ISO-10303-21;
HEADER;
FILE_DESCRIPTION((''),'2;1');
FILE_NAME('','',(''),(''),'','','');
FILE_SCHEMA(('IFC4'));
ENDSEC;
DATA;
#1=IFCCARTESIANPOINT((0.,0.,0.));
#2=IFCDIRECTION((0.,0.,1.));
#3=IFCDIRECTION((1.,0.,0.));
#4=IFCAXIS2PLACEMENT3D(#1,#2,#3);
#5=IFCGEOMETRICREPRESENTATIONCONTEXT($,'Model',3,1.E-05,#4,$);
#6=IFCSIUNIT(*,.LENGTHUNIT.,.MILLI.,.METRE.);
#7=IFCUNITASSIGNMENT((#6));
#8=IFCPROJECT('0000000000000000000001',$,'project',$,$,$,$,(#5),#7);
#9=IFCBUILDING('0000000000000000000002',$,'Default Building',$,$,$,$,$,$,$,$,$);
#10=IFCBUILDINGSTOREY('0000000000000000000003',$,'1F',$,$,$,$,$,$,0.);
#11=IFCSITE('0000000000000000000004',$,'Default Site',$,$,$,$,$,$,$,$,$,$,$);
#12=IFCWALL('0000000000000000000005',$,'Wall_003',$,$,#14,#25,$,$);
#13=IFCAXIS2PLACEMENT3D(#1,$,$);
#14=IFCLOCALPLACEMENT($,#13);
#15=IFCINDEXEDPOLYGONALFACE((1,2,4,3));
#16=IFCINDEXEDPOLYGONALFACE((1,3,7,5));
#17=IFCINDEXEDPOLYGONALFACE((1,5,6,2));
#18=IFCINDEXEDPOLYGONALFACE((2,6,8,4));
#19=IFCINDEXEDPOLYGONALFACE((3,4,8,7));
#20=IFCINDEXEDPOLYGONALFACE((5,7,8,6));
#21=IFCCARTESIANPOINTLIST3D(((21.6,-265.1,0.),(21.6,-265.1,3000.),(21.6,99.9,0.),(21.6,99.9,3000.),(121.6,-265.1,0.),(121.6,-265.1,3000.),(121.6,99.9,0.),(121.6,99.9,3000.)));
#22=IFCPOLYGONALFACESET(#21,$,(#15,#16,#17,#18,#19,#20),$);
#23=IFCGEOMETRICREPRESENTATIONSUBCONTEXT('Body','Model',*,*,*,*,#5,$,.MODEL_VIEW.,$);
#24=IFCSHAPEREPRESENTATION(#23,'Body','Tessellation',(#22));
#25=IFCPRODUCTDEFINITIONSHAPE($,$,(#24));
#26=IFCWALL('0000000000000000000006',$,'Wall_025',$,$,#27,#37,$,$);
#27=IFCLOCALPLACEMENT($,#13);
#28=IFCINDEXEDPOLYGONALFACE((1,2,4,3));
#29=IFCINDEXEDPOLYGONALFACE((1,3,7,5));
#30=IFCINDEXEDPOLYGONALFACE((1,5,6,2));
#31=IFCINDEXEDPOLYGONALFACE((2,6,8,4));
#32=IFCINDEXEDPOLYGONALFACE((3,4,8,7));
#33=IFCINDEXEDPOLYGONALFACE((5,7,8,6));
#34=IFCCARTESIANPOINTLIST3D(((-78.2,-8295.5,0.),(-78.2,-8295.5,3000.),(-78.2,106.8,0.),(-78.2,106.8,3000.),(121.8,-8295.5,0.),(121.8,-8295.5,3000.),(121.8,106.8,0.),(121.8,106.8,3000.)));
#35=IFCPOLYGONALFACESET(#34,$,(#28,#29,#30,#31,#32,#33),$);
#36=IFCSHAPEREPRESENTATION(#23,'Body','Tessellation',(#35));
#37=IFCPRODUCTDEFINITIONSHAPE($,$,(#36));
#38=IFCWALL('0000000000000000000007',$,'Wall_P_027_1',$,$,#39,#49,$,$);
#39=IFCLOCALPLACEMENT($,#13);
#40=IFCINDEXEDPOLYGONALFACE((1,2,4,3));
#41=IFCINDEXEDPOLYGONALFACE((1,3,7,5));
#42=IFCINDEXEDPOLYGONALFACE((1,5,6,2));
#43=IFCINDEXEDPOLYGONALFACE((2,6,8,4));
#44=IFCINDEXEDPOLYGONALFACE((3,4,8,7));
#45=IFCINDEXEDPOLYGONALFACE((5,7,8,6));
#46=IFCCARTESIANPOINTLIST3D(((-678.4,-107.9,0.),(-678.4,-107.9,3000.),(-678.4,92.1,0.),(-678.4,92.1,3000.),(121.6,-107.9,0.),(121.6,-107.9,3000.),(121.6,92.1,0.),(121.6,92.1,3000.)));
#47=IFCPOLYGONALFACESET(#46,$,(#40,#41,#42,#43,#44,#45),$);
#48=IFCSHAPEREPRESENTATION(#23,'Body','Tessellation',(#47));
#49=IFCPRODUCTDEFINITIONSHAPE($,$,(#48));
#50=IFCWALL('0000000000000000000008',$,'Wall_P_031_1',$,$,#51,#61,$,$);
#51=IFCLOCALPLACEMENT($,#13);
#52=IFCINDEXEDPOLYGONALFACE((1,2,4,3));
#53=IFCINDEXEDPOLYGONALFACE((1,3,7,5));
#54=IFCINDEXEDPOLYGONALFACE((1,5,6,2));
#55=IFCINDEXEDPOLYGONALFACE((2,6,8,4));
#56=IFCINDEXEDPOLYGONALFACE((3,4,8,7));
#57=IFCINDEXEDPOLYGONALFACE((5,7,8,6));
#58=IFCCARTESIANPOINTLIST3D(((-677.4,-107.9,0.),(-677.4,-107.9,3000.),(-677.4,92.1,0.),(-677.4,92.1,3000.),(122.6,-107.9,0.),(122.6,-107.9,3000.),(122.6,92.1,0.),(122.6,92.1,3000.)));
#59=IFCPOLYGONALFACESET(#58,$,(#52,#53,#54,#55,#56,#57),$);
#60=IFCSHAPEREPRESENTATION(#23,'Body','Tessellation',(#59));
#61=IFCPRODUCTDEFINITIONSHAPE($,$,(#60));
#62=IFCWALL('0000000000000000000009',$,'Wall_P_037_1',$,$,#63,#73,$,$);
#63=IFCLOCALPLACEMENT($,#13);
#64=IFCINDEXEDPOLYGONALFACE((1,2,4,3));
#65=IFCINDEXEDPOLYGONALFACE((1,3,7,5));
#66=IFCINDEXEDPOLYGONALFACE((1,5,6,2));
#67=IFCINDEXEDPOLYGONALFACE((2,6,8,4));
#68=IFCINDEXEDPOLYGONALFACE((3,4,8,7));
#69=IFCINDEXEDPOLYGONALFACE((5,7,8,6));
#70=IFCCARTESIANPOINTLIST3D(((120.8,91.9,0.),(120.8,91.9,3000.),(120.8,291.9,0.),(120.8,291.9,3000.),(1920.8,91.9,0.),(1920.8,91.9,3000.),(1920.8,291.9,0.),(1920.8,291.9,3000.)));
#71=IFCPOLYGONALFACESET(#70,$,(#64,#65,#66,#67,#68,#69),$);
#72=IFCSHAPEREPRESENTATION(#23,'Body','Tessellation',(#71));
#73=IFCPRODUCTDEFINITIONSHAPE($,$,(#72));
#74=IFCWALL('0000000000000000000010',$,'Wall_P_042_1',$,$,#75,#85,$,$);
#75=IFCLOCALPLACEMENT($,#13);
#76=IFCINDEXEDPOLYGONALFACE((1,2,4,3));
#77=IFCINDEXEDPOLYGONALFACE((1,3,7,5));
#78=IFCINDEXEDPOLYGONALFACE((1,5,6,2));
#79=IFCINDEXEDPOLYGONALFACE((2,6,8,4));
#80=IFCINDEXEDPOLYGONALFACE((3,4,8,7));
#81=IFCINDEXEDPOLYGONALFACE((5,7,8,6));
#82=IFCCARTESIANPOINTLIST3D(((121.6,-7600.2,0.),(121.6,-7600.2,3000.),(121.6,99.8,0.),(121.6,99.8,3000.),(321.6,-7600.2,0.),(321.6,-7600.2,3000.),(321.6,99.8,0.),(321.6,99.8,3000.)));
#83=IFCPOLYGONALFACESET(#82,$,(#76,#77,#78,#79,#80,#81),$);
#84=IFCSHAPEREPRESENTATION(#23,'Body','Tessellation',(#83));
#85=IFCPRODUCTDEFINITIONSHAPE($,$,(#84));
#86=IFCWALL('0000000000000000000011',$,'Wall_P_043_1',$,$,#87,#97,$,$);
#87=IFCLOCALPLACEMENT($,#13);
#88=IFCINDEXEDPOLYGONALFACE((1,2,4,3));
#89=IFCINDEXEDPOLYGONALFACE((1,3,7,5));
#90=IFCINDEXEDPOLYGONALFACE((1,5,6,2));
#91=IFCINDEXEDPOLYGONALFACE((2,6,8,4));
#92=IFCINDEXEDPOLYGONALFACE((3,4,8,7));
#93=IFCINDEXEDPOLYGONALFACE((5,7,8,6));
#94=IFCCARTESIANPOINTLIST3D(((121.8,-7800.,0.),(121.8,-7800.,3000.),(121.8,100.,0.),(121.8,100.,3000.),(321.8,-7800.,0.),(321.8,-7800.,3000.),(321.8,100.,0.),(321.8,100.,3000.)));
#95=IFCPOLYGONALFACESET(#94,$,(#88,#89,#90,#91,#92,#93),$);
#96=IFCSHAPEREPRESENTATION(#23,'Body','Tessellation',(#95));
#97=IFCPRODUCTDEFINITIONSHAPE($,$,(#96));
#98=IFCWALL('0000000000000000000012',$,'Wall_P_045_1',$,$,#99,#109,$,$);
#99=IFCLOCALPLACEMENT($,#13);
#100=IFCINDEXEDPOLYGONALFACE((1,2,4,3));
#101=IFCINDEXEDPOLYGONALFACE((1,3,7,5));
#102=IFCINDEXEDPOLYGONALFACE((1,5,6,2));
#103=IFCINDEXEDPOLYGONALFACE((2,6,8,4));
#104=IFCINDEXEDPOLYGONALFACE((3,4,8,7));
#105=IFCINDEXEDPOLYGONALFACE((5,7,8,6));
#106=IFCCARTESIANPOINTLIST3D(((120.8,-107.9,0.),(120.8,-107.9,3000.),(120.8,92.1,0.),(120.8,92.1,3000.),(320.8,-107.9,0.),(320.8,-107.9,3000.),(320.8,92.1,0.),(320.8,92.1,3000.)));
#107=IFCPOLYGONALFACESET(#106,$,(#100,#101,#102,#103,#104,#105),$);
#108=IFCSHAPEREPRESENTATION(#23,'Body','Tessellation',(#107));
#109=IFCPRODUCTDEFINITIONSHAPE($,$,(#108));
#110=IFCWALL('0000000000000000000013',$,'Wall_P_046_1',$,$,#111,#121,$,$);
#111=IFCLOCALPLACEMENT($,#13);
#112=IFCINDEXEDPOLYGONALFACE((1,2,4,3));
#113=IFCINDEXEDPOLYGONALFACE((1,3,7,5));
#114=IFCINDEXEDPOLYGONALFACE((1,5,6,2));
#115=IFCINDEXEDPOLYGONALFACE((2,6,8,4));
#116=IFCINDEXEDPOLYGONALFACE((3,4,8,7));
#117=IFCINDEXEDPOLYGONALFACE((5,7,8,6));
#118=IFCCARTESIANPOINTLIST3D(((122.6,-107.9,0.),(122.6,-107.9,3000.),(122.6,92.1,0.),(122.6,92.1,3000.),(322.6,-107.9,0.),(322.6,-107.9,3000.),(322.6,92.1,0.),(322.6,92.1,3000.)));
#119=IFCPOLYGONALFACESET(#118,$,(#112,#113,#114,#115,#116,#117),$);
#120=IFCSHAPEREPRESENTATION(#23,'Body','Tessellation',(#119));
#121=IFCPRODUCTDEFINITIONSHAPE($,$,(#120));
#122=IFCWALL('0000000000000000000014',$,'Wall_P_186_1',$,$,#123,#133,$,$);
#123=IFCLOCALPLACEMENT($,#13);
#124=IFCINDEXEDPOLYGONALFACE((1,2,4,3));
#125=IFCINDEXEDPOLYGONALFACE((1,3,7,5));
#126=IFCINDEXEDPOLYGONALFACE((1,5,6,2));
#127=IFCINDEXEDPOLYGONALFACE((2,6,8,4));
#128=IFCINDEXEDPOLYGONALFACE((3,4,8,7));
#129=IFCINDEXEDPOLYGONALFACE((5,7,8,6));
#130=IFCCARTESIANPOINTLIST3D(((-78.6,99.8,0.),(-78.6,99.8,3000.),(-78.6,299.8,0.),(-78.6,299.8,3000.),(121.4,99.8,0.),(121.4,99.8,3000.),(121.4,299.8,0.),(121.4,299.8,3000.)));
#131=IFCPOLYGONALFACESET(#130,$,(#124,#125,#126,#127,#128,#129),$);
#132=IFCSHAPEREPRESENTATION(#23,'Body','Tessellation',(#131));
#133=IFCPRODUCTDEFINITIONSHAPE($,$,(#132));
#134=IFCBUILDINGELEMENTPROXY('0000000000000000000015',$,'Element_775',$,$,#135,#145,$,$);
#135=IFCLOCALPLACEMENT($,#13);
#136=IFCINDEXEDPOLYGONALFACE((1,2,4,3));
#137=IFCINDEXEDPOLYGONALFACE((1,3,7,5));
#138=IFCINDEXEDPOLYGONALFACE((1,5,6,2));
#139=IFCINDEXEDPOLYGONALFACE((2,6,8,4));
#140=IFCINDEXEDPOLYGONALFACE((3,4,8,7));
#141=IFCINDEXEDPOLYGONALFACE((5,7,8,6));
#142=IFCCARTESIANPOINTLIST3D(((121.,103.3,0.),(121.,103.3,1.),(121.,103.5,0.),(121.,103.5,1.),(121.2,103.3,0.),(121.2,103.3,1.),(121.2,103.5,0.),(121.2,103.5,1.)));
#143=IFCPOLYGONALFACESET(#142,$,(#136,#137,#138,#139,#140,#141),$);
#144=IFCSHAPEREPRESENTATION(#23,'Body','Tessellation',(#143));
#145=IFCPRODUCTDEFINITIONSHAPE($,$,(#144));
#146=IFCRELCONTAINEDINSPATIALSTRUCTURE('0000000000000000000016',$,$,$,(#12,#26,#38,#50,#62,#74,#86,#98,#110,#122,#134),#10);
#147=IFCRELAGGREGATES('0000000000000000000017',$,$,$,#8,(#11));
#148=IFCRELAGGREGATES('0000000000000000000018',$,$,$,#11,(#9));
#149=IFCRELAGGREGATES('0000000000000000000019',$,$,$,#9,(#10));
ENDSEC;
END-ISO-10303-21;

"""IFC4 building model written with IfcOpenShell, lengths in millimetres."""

from ifc_helpers import new_model, si_unit, frame, origin, origin_with_axes, place, context, subcontext, project, spatial, polyline, indexed_curve, outline, extrude, element, save


model = new_model("IFC4")

# Units and contexts
model_context = context("Model", 3, precision=1e-05, world=origin_with_axes())
body_context = subcontext(model_context, "Body", "Model", "MODEL_VIEW")
ifc_project = project(units=[si_unit("LENGTHUNIT", "METRE", prefix="MILLI")], contexts=[model_context])

# Site, building, storey
site = spatial("IfcSite", under=ifc_project, Name="Default Site")
building = spatial("IfcBuilding", under=site, Name="Default Building")
storey = spatial("IfcBuildingStorey", under=building, Name="1F", Elevation=0.0)

# Walls
wall_1_placement = place(None, frame((121.6, 99.9, 0.0), z_axis=(0.0, 0.0, 1.0), x_axis=(-1.0, 0.0, 0.0)))
element("IfcWall", 1, at=wall_1_placement, inside=storey, Name="Wall_003", context=body_context, shape_type="SweptSolid", body=[
    extrude(outline(indexed_curve([(0.0, 0.0), (0.0, 365.0), (100.0, 365.0), (100.0, 0.0), (0.0, 0.0)], self_intersect=False)), origin_with_axes(), (0.0, 0.0, 1.0), 3000.0),
])
wall_2_placement = place(None, frame((121.8, 106.8, 0.0), z_axis=(0.0, 0.0, 1.0), x_axis=(-1.0, 0.0, 0.0)))
element("IfcWall", 2, at=wall_2_placement, inside=storey, Name="Wall_025", context=body_context, shape_type="SweptSolid", body=[
    extrude(outline(indexed_curve([(0.0, 0.0), (0.0, 8402.4), (200.0, 8402.4), (200.0, 0.0), (0.0, 0.0)], self_intersect=False)), origin_with_axes(), (0.0, 0.0, 1.0), 3000.0),
])
wall_3_placement = place(None, frame((121.6, 92.1, 0.0), z_axis=(0.0, 0.0, 1.0), x_axis=(-1.0, 0.0, 0.0)))
element("IfcWall", 3, at=wall_3_placement, inside=storey, Name="Wall_P_027_1", context=body_context, shape_type="SweptSolid", body=[
    extrude(outline(indexed_curve([(0.0, 0.0), (0.0, 200.0), (800.0, 200.0), (800.0, 0.0), (0.0, 0.0)], self_intersect=False)), origin_with_axes(), (0.0, 0.0, 1.0), 3000.0),
])
wall_4_placement = place(None, frame((122.6, 92.1, 0.0), z_axis=(0.0, 0.0, 1.0), x_axis=(-1.0, 0.0, 0.0)))
element("IfcWall", 4, at=wall_4_placement, inside=storey, Name="Wall_P_031_1", context=body_context, shape_type="SweptSolid", body=[
    extrude(outline(indexed_curve([(0.0, 0.0), (0.0, 200.0), (800.0, 200.0), (800.0, 0.0), (0.0, 0.0)], self_intersect=False)), origin_with_axes(), (0.0, 0.0, 1.0), 3000.0),
])
wall_5_placement = place(None, frame((120.8, 91.9, 0.0), z_axis=(0.0, 0.0, 1.0), x_axis=(1.0, 0.0, 0.0)))
element("IfcWall", 5, at=wall_5_placement, inside=storey, Name="Wall_P_037_1", context=body_context, shape_type="SweptSolid", body=[
    extrude(outline(indexed_curve([(0.0, 0.0), (0.0, 200.0), (1800.0, 200.0), (1800.0, 0.0), (0.0, 0.0)], self_intersect=False)), origin_with_axes(), (0.0, 0.0, 1.0), 3000.0),
])
wall_6_placement = place(None, frame((121.6, 99.8, 0.0), z_axis=(0.0, 0.0, 1.0), x_axis=(0.0, -1.0, 0.0)))
element("IfcWall", 6, at=wall_6_placement, inside=storey, Name="Wall_P_042_1", context=body_context, shape_type="SweptSolid", body=[
    extrude(outline(indexed_curve([(0.0, 0.0), (0.0, 200.0), (7700.0, 200.0), (7700.0, 0.0), (0.0, 0.0)], self_intersect=False)), origin_with_axes(), (0.0, 0.0, 1.0), 3000.0),
])
wall_7_placement = place(None, frame((121.8, 100.0, 0.0), z_axis=(0.0, 0.0, 1.0), x_axis=(0.0, -1.0, 0.0)))
element("IfcWall", 7, at=wall_7_placement, inside=storey, Name="Wall_P_043_1", context=body_context, shape_type="SweptSolid", body=[
    extrude(outline(indexed_curve([(0.0, 0.0), (0.0, 200.0), (7900.0, 200.0), (7900.0, 0.0), (0.0, 0.0)], self_intersect=False)), origin_with_axes(), (0.0, 0.0, 1.0), 3000.0),
])
for number, where, z_axis, x_axis, name in (
    (8, (120.8, 92.1, 0.0), (0.0, 0.0, 1.0), (0.0, -1.0, 0.0), "Wall_P_045_1"),
    (9, (122.6, 92.1, 0.0), (0.0, 0.0, 1.0), (0.0, -1.0, 0.0), "Wall_P_046_1"),
):
    element("IfcWall", number, at=place(None, frame(where, z_axis=z_axis, x_axis=x_axis)), inside=storey, Name=name, context=body_context, shape_type="SweptSolid", body=[
        extrude(outline(indexed_curve([(0.0, 0.0), (0.0, 200.0), (200.0, 200.0), (200.0, 0.0), (0.0, 0.0)], self_intersect=False)), origin_with_axes(), (0.0, 0.0, 1.0), 3000.0),
    ])
wall_8_placement = place(None, frame((121.4, 99.8, 0.0), z_axis=(0.0, 0.0, 1.0), x_axis=(0.0, 1.0, 0.0)))
element("IfcWall", 10, at=wall_8_placement, inside=storey, Name="Wall_P_186_1", context=body_context, shape_type="SweptSolid", body=[
    extrude(outline(indexed_curve([(0.0, 0.0), (0.0, 200.0), (200.0, 200.0), (200.0, 0.0), (0.0, 0.0)], self_intersect=False)), origin_with_axes(), (0.0, 0.0, 1.0), 3000.0),
])

# Building element proxy
proxy_1_placement = place(None, frame((121.1, 103.4, 0.0), z_axis=(0.0, 0.0, 1.0), x_axis=(1.0, 0.0, 0.0)))
element("IfcBuildingElementProxy", 11, at=proxy_1_placement, inside=storey, Name="Element_775", context=body_context, shape_type="SweptSolid", body=[
    extrude(outline(polyline([(-0.1, 0.1), (0.1, 0.1), (0.1, -0.1), (-0.1, -0.1), (-0.1, 0.1)])), origin(), (0.0, 0.0, 1.0), 1.0),
])

save(model, "model.ifc")
